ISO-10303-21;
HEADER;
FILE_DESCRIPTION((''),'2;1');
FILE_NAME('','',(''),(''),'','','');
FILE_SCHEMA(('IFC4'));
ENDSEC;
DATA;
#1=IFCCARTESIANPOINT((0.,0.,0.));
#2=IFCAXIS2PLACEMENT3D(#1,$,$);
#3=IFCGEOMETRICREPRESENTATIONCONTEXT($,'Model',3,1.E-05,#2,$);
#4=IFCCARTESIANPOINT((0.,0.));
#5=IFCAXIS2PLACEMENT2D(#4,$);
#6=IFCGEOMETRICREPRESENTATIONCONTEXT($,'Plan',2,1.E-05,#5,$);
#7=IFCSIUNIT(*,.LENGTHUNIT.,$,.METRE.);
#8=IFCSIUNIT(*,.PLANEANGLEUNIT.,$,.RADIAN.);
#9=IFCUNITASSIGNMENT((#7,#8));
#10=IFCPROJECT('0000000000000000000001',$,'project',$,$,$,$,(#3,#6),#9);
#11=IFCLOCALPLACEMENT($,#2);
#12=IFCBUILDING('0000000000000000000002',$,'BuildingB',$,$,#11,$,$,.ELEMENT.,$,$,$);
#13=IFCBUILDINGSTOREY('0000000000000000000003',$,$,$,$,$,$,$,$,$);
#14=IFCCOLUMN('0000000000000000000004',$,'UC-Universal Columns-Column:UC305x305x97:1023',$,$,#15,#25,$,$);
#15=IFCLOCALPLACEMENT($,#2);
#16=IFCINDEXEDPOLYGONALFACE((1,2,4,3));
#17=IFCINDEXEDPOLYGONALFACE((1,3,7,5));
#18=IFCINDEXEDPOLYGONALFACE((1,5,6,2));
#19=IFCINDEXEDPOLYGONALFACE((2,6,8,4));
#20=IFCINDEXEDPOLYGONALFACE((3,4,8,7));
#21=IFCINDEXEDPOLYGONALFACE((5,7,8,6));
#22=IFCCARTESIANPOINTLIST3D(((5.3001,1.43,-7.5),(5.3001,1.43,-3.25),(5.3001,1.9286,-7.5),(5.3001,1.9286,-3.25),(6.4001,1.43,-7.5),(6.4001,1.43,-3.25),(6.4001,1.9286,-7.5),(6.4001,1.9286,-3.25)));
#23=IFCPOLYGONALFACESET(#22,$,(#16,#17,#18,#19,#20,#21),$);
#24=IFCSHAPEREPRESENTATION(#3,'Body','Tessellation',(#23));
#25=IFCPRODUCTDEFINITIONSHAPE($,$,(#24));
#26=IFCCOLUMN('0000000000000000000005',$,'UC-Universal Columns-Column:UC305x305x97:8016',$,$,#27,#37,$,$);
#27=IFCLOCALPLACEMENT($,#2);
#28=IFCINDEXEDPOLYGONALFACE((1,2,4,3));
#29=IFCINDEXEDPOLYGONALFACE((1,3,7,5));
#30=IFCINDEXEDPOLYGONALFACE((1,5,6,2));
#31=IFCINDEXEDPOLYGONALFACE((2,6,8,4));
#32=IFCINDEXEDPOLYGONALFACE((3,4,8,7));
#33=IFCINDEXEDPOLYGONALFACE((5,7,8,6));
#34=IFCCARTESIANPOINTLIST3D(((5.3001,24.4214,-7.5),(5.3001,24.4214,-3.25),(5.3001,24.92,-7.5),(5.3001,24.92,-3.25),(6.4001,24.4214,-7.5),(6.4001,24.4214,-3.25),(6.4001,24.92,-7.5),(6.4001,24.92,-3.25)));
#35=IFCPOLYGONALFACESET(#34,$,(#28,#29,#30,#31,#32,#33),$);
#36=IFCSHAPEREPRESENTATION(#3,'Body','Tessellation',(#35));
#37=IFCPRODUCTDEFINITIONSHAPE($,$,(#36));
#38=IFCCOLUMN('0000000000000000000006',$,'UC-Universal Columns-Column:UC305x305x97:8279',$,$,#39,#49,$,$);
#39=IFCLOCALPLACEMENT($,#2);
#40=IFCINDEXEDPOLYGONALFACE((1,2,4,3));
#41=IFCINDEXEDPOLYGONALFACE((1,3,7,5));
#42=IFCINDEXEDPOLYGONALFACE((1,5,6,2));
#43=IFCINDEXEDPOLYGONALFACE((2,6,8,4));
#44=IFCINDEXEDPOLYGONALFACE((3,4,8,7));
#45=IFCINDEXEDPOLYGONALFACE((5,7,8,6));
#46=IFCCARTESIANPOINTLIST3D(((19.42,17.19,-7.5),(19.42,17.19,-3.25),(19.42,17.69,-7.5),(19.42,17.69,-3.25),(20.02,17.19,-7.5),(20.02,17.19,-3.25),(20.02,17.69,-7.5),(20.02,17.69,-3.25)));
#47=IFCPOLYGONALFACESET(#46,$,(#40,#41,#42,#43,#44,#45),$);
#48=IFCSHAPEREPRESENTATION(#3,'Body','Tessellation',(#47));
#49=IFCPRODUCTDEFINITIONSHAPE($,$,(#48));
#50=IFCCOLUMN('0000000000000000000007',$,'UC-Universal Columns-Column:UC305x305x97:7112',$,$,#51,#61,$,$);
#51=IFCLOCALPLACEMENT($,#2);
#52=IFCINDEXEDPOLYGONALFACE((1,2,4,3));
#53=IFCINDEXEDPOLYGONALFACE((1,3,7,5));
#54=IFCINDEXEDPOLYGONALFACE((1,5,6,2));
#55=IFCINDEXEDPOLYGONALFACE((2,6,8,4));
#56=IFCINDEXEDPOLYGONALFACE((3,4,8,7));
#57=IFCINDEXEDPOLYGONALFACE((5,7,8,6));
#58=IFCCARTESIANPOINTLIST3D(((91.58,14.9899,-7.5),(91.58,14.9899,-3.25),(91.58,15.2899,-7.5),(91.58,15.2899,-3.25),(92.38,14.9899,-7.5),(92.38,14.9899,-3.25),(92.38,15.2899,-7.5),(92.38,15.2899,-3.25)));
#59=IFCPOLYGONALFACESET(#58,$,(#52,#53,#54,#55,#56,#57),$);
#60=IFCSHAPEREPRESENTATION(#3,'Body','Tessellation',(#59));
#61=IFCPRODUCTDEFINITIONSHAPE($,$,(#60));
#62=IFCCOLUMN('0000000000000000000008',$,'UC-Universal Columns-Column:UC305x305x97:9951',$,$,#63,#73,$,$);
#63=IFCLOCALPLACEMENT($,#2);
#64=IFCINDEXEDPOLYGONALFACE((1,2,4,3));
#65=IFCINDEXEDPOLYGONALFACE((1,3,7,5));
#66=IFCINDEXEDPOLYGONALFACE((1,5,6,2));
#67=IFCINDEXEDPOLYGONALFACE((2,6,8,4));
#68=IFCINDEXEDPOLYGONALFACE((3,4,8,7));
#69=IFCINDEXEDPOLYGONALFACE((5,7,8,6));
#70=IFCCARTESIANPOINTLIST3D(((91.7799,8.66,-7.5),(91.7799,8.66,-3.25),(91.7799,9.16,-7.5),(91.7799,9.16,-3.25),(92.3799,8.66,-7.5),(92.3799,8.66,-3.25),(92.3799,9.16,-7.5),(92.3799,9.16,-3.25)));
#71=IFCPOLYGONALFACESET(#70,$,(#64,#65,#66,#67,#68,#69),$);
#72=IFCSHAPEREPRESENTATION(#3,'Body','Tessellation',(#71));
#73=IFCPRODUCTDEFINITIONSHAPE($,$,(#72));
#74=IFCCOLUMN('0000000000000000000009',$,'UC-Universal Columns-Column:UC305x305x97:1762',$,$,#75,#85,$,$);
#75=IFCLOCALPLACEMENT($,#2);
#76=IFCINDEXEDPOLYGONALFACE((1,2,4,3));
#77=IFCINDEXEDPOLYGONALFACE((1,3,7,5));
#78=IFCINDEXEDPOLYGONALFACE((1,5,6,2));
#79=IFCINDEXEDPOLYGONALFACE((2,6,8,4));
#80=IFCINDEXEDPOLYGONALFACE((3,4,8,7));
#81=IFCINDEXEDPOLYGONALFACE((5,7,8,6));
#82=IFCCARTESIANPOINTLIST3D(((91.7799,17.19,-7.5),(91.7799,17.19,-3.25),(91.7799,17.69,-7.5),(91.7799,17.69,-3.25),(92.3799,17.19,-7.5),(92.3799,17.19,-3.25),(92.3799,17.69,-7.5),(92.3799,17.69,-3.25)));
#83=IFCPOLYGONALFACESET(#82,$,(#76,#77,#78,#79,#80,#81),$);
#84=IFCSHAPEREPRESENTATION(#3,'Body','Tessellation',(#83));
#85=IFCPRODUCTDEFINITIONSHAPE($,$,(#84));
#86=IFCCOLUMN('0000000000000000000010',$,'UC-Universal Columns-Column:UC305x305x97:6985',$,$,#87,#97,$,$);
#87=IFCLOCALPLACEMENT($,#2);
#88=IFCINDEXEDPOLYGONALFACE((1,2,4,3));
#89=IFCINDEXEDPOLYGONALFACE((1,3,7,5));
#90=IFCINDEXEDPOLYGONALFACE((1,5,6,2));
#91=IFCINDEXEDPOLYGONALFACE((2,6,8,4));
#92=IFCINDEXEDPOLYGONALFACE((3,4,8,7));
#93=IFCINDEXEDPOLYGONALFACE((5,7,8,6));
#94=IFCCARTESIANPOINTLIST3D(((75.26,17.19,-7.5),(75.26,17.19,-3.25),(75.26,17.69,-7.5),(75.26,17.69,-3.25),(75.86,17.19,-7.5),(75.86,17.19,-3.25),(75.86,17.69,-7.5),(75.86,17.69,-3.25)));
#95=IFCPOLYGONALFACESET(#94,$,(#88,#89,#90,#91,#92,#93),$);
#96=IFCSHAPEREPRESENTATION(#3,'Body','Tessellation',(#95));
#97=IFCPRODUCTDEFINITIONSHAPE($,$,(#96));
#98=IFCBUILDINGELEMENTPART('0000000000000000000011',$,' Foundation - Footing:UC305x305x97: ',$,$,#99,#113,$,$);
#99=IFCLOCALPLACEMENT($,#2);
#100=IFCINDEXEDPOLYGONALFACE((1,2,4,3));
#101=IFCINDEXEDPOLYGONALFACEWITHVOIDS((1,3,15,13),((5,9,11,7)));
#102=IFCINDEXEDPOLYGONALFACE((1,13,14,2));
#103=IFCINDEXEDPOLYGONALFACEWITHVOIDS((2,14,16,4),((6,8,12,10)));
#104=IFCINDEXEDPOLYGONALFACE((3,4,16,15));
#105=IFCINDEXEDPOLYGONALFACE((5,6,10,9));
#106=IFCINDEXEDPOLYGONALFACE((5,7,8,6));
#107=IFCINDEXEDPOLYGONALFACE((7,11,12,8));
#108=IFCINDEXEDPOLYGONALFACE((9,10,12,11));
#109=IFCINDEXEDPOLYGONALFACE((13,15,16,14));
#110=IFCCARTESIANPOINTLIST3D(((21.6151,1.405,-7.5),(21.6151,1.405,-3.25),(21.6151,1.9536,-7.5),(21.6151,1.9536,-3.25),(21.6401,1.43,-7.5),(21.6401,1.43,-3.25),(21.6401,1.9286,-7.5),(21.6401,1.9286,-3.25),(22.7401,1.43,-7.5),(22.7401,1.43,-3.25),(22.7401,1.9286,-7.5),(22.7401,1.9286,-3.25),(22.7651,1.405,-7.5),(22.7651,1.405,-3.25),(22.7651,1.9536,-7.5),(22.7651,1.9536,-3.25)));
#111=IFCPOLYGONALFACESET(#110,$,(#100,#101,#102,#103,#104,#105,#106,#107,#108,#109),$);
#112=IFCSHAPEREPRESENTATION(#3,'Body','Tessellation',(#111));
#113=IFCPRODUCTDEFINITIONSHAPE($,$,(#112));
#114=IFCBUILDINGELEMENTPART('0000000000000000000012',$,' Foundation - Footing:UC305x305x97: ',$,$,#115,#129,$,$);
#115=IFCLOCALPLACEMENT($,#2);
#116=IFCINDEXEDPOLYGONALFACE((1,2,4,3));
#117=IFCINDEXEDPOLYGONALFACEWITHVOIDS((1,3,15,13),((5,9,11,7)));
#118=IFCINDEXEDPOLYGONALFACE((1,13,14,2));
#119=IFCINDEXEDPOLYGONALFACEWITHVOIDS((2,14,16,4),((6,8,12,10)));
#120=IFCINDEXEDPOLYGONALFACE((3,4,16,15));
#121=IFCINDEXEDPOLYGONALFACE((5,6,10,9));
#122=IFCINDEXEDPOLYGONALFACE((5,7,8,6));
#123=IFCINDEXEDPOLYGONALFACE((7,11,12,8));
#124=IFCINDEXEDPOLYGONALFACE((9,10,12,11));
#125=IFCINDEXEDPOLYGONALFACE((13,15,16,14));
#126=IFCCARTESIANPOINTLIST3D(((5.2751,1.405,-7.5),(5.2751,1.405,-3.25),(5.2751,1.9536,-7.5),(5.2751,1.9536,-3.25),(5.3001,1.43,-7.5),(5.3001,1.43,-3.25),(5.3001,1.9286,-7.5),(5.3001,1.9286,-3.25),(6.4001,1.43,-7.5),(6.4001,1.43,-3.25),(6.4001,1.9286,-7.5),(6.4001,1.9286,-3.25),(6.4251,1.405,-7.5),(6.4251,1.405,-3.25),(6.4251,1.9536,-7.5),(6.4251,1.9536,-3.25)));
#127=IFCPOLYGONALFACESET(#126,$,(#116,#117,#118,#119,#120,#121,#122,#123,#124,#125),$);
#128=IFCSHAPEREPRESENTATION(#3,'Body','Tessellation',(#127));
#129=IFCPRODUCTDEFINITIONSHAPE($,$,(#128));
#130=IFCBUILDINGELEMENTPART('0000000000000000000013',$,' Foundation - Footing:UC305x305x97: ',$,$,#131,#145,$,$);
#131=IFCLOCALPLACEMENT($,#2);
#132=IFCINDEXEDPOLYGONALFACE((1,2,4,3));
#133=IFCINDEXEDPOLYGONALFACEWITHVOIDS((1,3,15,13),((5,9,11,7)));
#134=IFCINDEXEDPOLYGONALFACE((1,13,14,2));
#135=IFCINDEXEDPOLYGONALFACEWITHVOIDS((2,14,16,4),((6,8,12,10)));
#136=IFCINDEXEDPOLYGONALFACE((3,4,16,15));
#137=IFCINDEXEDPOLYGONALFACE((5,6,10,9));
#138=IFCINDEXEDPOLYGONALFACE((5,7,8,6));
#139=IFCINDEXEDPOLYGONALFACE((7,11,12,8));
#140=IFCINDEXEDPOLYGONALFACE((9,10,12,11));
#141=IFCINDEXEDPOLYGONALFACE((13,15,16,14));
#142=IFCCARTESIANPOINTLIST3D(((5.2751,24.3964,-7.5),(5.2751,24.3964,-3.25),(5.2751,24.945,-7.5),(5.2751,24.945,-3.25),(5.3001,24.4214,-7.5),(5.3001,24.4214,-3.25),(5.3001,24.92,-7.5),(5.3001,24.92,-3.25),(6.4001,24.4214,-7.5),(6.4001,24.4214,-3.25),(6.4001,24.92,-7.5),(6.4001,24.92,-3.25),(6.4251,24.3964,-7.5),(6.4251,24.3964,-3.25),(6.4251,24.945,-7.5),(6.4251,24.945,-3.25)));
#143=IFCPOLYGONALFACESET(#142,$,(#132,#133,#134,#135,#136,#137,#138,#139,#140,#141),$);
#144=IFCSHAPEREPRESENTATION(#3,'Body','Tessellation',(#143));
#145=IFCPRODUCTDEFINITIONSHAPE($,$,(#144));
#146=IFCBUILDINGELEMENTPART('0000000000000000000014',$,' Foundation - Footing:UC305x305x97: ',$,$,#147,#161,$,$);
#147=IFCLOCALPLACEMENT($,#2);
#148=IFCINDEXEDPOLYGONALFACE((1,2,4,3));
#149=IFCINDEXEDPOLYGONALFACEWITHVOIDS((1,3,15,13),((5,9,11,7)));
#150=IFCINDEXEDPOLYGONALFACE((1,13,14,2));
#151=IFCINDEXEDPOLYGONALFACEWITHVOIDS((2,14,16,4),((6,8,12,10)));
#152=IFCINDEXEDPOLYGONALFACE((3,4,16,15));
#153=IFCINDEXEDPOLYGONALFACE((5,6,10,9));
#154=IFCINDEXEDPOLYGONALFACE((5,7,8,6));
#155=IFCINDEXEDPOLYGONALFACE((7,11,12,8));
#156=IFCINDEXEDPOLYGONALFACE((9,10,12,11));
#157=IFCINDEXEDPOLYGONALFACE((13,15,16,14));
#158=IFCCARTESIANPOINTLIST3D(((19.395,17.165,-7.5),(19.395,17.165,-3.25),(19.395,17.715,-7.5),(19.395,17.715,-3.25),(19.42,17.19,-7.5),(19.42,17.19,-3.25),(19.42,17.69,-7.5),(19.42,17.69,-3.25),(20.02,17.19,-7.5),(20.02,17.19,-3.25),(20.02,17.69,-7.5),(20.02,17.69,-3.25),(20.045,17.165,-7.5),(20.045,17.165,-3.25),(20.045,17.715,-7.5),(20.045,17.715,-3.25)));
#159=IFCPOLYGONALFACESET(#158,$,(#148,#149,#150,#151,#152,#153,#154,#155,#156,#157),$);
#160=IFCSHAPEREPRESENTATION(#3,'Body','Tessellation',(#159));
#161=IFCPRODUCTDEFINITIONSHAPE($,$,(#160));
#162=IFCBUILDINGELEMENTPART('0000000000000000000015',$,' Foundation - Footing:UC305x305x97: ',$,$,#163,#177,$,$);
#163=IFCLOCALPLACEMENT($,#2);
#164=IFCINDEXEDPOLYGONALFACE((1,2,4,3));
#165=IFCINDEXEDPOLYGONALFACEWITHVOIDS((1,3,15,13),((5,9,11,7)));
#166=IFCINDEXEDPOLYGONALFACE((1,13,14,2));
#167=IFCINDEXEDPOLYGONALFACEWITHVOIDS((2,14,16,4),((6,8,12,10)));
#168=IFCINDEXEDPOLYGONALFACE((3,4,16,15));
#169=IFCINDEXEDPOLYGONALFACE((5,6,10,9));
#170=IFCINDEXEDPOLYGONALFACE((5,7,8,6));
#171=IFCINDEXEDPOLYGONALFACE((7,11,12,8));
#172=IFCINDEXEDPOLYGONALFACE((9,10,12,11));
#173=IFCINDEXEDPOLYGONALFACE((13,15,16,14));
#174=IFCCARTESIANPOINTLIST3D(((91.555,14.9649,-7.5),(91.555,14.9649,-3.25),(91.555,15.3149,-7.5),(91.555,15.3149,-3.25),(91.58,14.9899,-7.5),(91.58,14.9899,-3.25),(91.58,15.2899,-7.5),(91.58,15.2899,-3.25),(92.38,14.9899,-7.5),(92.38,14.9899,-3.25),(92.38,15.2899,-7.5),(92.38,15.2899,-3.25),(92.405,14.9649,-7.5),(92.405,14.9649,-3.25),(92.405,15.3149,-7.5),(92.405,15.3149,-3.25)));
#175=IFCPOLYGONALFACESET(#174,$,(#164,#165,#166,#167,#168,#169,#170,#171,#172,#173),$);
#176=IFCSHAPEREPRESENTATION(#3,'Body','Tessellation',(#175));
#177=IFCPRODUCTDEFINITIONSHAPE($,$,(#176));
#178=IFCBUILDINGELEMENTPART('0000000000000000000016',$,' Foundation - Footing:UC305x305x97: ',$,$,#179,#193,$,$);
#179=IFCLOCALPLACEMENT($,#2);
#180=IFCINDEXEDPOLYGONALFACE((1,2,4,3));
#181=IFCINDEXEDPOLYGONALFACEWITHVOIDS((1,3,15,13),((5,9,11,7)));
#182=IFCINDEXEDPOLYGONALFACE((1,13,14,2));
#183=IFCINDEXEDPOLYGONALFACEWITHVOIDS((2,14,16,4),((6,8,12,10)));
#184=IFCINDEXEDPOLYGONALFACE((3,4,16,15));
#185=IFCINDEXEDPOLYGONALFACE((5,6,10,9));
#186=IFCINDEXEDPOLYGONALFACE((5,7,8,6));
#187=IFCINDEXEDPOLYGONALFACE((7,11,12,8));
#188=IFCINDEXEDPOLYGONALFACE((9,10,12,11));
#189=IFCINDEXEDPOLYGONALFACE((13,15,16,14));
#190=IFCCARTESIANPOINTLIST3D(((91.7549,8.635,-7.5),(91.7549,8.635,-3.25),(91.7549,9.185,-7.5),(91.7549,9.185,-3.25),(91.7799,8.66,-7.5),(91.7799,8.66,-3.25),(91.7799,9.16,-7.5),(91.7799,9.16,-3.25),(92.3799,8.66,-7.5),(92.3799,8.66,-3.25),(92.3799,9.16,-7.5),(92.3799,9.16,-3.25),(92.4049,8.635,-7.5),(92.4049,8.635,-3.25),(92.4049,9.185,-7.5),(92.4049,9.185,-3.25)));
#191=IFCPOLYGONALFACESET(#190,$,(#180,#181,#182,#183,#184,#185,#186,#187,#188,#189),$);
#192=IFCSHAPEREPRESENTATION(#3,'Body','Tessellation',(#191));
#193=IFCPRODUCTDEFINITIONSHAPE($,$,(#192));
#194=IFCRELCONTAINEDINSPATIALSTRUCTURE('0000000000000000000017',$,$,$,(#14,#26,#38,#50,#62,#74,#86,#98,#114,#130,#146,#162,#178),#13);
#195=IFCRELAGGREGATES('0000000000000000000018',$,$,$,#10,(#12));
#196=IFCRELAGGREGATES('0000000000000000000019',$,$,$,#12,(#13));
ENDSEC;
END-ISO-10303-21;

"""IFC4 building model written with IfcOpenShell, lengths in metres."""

from ifc_helpers import new_model, si_unit, origin, origin_2d, place, context, project, spatial, polyline, outline, extrude, element, save


model = new_model("IFC4")

# Units and contexts
model_context = context("Model", 3, precision=1e-05, world=origin())
plan_context = context("Plan", 2, precision=1e-05, world=origin_2d())
ifc_project = project(units=[si_unit("LENGTHUNIT", "METRE"), si_unit("PLANEANGLEUNIT", "RADIAN")], contexts=[model_context, plan_context])

# Building, storey
building_placement = place(None, origin())
building = spatial("IfcBuilding", under=ifc_project, at=building_placement, Name="BuildingB", CompositionType="ELEMENT")
storey = spatial("IfcBuildingStorey", under=building)

# Columns
element("IfcColumn", 1, inside=storey, Name="UC-Universal Columns-Column:UC305x305x97:1023", context=model_context, shape_type="SweptSolid", body=[
    extrude(outline(polyline([(5.3001, 1.43, -7.5), (6.4001, 1.43, -7.5), (6.4001, 1.9286, -7.5), (5.3001, 1.9286, -7.5), (5.3001, 1.43, -7.5)])), None, (0.0, 0.0, 1.0), 4.25),
])
element("IfcColumn", 2, inside=storey, Name="UC-Universal Columns-Column:UC305x305x97:8016", context=model_context, shape_type="SweptSolid", body=[
    extrude(outline(polyline([(5.3001, 24.4214, -7.5), (6.4001, 24.4214, -7.5), (6.4001, 24.92, -7.5), (5.3001, 24.92, -7.5), (5.3001, 24.4214, -7.5)])), None, (0.0, 0.0, 1.0), 4.25),
])
element("IfcColumn", 3, inside=storey, Name="UC-Universal Columns-Column:UC305x305x97:8279", context=model_context, shape_type="SweptSolid", body=[
    extrude(outline(polyline([(19.42, 17.69, -7.5), (20.02, 17.69, -7.5), (20.02, 17.19, -7.5), (19.42, 17.19, -7.5), (19.42, 17.69, -7.5)])), None, (0.0, 0.0, 1.0), 4.25),
])
element("IfcColumn", 4, inside=storey, Name="UC-Universal Columns-Column:UC305x305x97:7112", context=model_context, shape_type="SweptSolid", body=[
    extrude(outline(polyline([(92.38, 15.2899, -7.5), (91.58, 15.2899, -7.5), (91.58, 14.9899, -7.5), (92.38, 14.9899, -7.5), (92.38, 15.2899, -7.5)])), None, (0.0, 0.0, 1.0), 4.25),
])
element("IfcColumn", 5, inside=storey, Name="UC-Universal Columns-Column:UC305x305x97:9951", context=model_context, shape_type="SweptSolid", body=[
    extrude(outline(polyline([(92.3799, 8.66, -7.5), (91.7799, 8.66, -7.5), (91.7799, 9.16, -7.5), (92.3799, 9.16, -7.5), (92.3799, 8.66, -7.5)])), None, (0.0, 0.0, 1.0), 4.25),
])
element("IfcColumn", 6, inside=storey, Name="UC-Universal Columns-Column:UC305x305x97:1762", context=model_context, shape_type="SweptSolid", body=[
    extrude(outline(polyline([(92.3799, 17.69, -7.5), (91.7799, 17.69, -7.5), (91.7799, 17.19, -7.5), (92.3799, 17.19, -7.5), (92.3799, 17.69, -7.5)])), None, (0.0, 0.0, 1.0), 4.25),
])
element("IfcColumn", 7, inside=storey, Name="UC-Universal Columns-Column:UC305x305x97:6985", context=model_context, shape_type="SweptSolid", body=[
    extrude(outline(polyline([(75.26, 17.69, -7.5), (75.86, 17.69, -7.5), (75.86, 17.19, -7.5), (75.26, 17.19, -7.5), (75.26, 17.69, -7.5)])), None, (0.0, 0.0, 1.0), 4.25),
])

# Building element parts, openings
building_element_part_1 = element("IfcBuildingElementPart", 8, inside=storey, Name=" Foundation - Footing:UC305x305x97: ", context=model_context, shape_type="SweptSolid", body=[
    extrude(outline(polyline([(21.6151, 1.405, -7.5), (22.7651, 1.405, -7.5), (22.7651, 1.9536, -7.5), (21.6151, 1.9536, -7.5), (21.6151, 1.405, -7.5)])), None, (0.0, 0.0, 1.0), 4.25),
])
element("IfcOpeningElement", 9, inside=storey, cuts=building_element_part_1, context=model_context, shape_type="SweptSolid", body=[
    extrude(outline(polyline([(21.6401, 1.43, -7.5), (22.7401, 1.43, -7.5), (22.7401, 1.9286, -7.5), (21.6401, 1.9286, -7.5), (21.6401, 1.43, -7.5)])), None, (0.0, 0.0, 1.0), 4.25),
])
building_element_part_2 = element("IfcBuildingElementPart", 10, inside=storey, Name=" Foundation - Footing:UC305x305x97: ", context=model_context, shape_type="SweptSolid", body=[
    extrude(outline(polyline([(5.2751, 1.405, -7.5), (6.4251, 1.405, -7.5), (6.4251, 1.9536, -7.5), (5.2751, 1.9536, -7.5), (5.2751, 1.405, -7.5)])), None, (0.0, 0.0, 1.0), 4.25),
])
element("IfcOpeningElement", 11, inside=storey, cuts=building_element_part_2, context=model_context, shape_type="SweptSolid", body=[
    extrude(outline(polyline([(5.3001, 1.43, -7.5), (6.4001, 1.43, -7.5), (6.4001, 1.9286, -7.5), (5.3001, 1.9286, -7.5), (5.3001, 1.43, -7.5)])), None, (0.0, 0.0, 1.0), 4.25),
])
building_element_part_3 = element("IfcBuildingElementPart", 12, inside=storey, Name=" Foundation - Footing:UC305x305x97: ", context=model_context, shape_type="SweptSolid", body=[
    extrude(outline(polyline([(5.2751, 24.3964, -7.5), (6.4251, 24.3964, -7.5), (6.4251, 24.945, -7.5), (5.2751, 24.945, -7.5), (5.2751, 24.3964, -7.5)])), None, (0.0, 0.0, 1.0), 4.25),
])
element("IfcOpeningElement", 13, inside=storey, cuts=building_element_part_3, context=model_context, shape_type="SweptSolid", body=[
    extrude(outline(polyline([(5.3001, 24.4214, -7.5), (6.4001, 24.4214, -7.5), (6.4001, 24.92, -7.5), (5.3001, 24.92, -7.5), (5.3001, 24.4214, -7.5)])), None, (0.0, 0.0, 1.0), 4.25),
])
building_element_part_4 = element("IfcBuildingElementPart", 14, inside=storey, Name=" Foundation - Footing:UC305x305x97: ", context=model_context, shape_type="SweptSolid", body=[
    extrude(outline(polyline([(19.395, 17.715, -7.5), (20.045, 17.715, -7.5), (20.045, 17.165, -7.5), (19.395, 17.165, -7.5), (19.395, 17.715, -7.5)])), None, (0.0, 0.0, 1.0), 4.25),
])
element("IfcOpeningElement", 15, inside=storey, cuts=building_element_part_4, context=model_context, shape_type="SweptSolid", body=[
    extrude(outline(polyline([(19.42, 17.69, -7.5), (20.02, 17.69, -7.5), (20.02, 17.19, -7.5), (19.42, 17.19, -7.5), (19.42, 17.69, -7.5)])), None, (0.0, 0.0, 1.0), 4.25),
])
building_element_part_5 = element("IfcBuildingElementPart", 16, inside=storey, Name=" Foundation - Footing:UC305x305x97: ", context=model_context, shape_type="SweptSolid", body=[
    extrude(outline(polyline([(92.405, 15.3149, -7.5), (91.555, 15.3149, -7.5), (91.555, 14.9649, -7.5), (92.405, 14.9649, -7.5), (92.405, 15.3149, -7.5)])), None, (0.0, 0.0, 1.0), 4.25),
])
element("IfcOpeningElement", 17, inside=storey, cuts=building_element_part_5, context=model_context, shape_type="SweptSolid", body=[
    extrude(outline(polyline([(92.38, 15.2899, -7.5), (91.58, 15.2899, -7.5), (91.58, 14.9899, -7.5), (92.38, 14.9899, -7.5), (92.38, 15.2899, -7.5)])), None, (0.0, 0.0, 1.0), 4.25),
])
building_element_part_6 = element("IfcBuildingElementPart", 18, inside=storey, Name=" Foundation - Footing:UC305x305x97: ", context=model_context, shape_type="SweptSolid", body=[
    extrude(outline(polyline([(92.4049, 8.635, -7.5), (91.7549, 8.635, -7.5), (91.7549, 9.185, -7.5), (92.4049, 9.185, -7.5), (92.4049, 8.635, -7.5)])), None, (0.0, 0.0, 1.0), 4.25),
])
element("IfcOpeningElement", 19, inside=storey, cuts=building_element_part_6, context=model_context, shape_type="SweptSolid", body=[
    extrude(outline(polyline([(92.3799, 8.66, -7.5), (91.7799, 8.66, -7.5), (91.7799, 9.16, -7.5), (92.3799, 9.16, -7.5), (92.3799, 8.66, -7.5)])), None, (0.0, 0.0, 1.0), 4.25),
])

save(model, "model.ifc")
